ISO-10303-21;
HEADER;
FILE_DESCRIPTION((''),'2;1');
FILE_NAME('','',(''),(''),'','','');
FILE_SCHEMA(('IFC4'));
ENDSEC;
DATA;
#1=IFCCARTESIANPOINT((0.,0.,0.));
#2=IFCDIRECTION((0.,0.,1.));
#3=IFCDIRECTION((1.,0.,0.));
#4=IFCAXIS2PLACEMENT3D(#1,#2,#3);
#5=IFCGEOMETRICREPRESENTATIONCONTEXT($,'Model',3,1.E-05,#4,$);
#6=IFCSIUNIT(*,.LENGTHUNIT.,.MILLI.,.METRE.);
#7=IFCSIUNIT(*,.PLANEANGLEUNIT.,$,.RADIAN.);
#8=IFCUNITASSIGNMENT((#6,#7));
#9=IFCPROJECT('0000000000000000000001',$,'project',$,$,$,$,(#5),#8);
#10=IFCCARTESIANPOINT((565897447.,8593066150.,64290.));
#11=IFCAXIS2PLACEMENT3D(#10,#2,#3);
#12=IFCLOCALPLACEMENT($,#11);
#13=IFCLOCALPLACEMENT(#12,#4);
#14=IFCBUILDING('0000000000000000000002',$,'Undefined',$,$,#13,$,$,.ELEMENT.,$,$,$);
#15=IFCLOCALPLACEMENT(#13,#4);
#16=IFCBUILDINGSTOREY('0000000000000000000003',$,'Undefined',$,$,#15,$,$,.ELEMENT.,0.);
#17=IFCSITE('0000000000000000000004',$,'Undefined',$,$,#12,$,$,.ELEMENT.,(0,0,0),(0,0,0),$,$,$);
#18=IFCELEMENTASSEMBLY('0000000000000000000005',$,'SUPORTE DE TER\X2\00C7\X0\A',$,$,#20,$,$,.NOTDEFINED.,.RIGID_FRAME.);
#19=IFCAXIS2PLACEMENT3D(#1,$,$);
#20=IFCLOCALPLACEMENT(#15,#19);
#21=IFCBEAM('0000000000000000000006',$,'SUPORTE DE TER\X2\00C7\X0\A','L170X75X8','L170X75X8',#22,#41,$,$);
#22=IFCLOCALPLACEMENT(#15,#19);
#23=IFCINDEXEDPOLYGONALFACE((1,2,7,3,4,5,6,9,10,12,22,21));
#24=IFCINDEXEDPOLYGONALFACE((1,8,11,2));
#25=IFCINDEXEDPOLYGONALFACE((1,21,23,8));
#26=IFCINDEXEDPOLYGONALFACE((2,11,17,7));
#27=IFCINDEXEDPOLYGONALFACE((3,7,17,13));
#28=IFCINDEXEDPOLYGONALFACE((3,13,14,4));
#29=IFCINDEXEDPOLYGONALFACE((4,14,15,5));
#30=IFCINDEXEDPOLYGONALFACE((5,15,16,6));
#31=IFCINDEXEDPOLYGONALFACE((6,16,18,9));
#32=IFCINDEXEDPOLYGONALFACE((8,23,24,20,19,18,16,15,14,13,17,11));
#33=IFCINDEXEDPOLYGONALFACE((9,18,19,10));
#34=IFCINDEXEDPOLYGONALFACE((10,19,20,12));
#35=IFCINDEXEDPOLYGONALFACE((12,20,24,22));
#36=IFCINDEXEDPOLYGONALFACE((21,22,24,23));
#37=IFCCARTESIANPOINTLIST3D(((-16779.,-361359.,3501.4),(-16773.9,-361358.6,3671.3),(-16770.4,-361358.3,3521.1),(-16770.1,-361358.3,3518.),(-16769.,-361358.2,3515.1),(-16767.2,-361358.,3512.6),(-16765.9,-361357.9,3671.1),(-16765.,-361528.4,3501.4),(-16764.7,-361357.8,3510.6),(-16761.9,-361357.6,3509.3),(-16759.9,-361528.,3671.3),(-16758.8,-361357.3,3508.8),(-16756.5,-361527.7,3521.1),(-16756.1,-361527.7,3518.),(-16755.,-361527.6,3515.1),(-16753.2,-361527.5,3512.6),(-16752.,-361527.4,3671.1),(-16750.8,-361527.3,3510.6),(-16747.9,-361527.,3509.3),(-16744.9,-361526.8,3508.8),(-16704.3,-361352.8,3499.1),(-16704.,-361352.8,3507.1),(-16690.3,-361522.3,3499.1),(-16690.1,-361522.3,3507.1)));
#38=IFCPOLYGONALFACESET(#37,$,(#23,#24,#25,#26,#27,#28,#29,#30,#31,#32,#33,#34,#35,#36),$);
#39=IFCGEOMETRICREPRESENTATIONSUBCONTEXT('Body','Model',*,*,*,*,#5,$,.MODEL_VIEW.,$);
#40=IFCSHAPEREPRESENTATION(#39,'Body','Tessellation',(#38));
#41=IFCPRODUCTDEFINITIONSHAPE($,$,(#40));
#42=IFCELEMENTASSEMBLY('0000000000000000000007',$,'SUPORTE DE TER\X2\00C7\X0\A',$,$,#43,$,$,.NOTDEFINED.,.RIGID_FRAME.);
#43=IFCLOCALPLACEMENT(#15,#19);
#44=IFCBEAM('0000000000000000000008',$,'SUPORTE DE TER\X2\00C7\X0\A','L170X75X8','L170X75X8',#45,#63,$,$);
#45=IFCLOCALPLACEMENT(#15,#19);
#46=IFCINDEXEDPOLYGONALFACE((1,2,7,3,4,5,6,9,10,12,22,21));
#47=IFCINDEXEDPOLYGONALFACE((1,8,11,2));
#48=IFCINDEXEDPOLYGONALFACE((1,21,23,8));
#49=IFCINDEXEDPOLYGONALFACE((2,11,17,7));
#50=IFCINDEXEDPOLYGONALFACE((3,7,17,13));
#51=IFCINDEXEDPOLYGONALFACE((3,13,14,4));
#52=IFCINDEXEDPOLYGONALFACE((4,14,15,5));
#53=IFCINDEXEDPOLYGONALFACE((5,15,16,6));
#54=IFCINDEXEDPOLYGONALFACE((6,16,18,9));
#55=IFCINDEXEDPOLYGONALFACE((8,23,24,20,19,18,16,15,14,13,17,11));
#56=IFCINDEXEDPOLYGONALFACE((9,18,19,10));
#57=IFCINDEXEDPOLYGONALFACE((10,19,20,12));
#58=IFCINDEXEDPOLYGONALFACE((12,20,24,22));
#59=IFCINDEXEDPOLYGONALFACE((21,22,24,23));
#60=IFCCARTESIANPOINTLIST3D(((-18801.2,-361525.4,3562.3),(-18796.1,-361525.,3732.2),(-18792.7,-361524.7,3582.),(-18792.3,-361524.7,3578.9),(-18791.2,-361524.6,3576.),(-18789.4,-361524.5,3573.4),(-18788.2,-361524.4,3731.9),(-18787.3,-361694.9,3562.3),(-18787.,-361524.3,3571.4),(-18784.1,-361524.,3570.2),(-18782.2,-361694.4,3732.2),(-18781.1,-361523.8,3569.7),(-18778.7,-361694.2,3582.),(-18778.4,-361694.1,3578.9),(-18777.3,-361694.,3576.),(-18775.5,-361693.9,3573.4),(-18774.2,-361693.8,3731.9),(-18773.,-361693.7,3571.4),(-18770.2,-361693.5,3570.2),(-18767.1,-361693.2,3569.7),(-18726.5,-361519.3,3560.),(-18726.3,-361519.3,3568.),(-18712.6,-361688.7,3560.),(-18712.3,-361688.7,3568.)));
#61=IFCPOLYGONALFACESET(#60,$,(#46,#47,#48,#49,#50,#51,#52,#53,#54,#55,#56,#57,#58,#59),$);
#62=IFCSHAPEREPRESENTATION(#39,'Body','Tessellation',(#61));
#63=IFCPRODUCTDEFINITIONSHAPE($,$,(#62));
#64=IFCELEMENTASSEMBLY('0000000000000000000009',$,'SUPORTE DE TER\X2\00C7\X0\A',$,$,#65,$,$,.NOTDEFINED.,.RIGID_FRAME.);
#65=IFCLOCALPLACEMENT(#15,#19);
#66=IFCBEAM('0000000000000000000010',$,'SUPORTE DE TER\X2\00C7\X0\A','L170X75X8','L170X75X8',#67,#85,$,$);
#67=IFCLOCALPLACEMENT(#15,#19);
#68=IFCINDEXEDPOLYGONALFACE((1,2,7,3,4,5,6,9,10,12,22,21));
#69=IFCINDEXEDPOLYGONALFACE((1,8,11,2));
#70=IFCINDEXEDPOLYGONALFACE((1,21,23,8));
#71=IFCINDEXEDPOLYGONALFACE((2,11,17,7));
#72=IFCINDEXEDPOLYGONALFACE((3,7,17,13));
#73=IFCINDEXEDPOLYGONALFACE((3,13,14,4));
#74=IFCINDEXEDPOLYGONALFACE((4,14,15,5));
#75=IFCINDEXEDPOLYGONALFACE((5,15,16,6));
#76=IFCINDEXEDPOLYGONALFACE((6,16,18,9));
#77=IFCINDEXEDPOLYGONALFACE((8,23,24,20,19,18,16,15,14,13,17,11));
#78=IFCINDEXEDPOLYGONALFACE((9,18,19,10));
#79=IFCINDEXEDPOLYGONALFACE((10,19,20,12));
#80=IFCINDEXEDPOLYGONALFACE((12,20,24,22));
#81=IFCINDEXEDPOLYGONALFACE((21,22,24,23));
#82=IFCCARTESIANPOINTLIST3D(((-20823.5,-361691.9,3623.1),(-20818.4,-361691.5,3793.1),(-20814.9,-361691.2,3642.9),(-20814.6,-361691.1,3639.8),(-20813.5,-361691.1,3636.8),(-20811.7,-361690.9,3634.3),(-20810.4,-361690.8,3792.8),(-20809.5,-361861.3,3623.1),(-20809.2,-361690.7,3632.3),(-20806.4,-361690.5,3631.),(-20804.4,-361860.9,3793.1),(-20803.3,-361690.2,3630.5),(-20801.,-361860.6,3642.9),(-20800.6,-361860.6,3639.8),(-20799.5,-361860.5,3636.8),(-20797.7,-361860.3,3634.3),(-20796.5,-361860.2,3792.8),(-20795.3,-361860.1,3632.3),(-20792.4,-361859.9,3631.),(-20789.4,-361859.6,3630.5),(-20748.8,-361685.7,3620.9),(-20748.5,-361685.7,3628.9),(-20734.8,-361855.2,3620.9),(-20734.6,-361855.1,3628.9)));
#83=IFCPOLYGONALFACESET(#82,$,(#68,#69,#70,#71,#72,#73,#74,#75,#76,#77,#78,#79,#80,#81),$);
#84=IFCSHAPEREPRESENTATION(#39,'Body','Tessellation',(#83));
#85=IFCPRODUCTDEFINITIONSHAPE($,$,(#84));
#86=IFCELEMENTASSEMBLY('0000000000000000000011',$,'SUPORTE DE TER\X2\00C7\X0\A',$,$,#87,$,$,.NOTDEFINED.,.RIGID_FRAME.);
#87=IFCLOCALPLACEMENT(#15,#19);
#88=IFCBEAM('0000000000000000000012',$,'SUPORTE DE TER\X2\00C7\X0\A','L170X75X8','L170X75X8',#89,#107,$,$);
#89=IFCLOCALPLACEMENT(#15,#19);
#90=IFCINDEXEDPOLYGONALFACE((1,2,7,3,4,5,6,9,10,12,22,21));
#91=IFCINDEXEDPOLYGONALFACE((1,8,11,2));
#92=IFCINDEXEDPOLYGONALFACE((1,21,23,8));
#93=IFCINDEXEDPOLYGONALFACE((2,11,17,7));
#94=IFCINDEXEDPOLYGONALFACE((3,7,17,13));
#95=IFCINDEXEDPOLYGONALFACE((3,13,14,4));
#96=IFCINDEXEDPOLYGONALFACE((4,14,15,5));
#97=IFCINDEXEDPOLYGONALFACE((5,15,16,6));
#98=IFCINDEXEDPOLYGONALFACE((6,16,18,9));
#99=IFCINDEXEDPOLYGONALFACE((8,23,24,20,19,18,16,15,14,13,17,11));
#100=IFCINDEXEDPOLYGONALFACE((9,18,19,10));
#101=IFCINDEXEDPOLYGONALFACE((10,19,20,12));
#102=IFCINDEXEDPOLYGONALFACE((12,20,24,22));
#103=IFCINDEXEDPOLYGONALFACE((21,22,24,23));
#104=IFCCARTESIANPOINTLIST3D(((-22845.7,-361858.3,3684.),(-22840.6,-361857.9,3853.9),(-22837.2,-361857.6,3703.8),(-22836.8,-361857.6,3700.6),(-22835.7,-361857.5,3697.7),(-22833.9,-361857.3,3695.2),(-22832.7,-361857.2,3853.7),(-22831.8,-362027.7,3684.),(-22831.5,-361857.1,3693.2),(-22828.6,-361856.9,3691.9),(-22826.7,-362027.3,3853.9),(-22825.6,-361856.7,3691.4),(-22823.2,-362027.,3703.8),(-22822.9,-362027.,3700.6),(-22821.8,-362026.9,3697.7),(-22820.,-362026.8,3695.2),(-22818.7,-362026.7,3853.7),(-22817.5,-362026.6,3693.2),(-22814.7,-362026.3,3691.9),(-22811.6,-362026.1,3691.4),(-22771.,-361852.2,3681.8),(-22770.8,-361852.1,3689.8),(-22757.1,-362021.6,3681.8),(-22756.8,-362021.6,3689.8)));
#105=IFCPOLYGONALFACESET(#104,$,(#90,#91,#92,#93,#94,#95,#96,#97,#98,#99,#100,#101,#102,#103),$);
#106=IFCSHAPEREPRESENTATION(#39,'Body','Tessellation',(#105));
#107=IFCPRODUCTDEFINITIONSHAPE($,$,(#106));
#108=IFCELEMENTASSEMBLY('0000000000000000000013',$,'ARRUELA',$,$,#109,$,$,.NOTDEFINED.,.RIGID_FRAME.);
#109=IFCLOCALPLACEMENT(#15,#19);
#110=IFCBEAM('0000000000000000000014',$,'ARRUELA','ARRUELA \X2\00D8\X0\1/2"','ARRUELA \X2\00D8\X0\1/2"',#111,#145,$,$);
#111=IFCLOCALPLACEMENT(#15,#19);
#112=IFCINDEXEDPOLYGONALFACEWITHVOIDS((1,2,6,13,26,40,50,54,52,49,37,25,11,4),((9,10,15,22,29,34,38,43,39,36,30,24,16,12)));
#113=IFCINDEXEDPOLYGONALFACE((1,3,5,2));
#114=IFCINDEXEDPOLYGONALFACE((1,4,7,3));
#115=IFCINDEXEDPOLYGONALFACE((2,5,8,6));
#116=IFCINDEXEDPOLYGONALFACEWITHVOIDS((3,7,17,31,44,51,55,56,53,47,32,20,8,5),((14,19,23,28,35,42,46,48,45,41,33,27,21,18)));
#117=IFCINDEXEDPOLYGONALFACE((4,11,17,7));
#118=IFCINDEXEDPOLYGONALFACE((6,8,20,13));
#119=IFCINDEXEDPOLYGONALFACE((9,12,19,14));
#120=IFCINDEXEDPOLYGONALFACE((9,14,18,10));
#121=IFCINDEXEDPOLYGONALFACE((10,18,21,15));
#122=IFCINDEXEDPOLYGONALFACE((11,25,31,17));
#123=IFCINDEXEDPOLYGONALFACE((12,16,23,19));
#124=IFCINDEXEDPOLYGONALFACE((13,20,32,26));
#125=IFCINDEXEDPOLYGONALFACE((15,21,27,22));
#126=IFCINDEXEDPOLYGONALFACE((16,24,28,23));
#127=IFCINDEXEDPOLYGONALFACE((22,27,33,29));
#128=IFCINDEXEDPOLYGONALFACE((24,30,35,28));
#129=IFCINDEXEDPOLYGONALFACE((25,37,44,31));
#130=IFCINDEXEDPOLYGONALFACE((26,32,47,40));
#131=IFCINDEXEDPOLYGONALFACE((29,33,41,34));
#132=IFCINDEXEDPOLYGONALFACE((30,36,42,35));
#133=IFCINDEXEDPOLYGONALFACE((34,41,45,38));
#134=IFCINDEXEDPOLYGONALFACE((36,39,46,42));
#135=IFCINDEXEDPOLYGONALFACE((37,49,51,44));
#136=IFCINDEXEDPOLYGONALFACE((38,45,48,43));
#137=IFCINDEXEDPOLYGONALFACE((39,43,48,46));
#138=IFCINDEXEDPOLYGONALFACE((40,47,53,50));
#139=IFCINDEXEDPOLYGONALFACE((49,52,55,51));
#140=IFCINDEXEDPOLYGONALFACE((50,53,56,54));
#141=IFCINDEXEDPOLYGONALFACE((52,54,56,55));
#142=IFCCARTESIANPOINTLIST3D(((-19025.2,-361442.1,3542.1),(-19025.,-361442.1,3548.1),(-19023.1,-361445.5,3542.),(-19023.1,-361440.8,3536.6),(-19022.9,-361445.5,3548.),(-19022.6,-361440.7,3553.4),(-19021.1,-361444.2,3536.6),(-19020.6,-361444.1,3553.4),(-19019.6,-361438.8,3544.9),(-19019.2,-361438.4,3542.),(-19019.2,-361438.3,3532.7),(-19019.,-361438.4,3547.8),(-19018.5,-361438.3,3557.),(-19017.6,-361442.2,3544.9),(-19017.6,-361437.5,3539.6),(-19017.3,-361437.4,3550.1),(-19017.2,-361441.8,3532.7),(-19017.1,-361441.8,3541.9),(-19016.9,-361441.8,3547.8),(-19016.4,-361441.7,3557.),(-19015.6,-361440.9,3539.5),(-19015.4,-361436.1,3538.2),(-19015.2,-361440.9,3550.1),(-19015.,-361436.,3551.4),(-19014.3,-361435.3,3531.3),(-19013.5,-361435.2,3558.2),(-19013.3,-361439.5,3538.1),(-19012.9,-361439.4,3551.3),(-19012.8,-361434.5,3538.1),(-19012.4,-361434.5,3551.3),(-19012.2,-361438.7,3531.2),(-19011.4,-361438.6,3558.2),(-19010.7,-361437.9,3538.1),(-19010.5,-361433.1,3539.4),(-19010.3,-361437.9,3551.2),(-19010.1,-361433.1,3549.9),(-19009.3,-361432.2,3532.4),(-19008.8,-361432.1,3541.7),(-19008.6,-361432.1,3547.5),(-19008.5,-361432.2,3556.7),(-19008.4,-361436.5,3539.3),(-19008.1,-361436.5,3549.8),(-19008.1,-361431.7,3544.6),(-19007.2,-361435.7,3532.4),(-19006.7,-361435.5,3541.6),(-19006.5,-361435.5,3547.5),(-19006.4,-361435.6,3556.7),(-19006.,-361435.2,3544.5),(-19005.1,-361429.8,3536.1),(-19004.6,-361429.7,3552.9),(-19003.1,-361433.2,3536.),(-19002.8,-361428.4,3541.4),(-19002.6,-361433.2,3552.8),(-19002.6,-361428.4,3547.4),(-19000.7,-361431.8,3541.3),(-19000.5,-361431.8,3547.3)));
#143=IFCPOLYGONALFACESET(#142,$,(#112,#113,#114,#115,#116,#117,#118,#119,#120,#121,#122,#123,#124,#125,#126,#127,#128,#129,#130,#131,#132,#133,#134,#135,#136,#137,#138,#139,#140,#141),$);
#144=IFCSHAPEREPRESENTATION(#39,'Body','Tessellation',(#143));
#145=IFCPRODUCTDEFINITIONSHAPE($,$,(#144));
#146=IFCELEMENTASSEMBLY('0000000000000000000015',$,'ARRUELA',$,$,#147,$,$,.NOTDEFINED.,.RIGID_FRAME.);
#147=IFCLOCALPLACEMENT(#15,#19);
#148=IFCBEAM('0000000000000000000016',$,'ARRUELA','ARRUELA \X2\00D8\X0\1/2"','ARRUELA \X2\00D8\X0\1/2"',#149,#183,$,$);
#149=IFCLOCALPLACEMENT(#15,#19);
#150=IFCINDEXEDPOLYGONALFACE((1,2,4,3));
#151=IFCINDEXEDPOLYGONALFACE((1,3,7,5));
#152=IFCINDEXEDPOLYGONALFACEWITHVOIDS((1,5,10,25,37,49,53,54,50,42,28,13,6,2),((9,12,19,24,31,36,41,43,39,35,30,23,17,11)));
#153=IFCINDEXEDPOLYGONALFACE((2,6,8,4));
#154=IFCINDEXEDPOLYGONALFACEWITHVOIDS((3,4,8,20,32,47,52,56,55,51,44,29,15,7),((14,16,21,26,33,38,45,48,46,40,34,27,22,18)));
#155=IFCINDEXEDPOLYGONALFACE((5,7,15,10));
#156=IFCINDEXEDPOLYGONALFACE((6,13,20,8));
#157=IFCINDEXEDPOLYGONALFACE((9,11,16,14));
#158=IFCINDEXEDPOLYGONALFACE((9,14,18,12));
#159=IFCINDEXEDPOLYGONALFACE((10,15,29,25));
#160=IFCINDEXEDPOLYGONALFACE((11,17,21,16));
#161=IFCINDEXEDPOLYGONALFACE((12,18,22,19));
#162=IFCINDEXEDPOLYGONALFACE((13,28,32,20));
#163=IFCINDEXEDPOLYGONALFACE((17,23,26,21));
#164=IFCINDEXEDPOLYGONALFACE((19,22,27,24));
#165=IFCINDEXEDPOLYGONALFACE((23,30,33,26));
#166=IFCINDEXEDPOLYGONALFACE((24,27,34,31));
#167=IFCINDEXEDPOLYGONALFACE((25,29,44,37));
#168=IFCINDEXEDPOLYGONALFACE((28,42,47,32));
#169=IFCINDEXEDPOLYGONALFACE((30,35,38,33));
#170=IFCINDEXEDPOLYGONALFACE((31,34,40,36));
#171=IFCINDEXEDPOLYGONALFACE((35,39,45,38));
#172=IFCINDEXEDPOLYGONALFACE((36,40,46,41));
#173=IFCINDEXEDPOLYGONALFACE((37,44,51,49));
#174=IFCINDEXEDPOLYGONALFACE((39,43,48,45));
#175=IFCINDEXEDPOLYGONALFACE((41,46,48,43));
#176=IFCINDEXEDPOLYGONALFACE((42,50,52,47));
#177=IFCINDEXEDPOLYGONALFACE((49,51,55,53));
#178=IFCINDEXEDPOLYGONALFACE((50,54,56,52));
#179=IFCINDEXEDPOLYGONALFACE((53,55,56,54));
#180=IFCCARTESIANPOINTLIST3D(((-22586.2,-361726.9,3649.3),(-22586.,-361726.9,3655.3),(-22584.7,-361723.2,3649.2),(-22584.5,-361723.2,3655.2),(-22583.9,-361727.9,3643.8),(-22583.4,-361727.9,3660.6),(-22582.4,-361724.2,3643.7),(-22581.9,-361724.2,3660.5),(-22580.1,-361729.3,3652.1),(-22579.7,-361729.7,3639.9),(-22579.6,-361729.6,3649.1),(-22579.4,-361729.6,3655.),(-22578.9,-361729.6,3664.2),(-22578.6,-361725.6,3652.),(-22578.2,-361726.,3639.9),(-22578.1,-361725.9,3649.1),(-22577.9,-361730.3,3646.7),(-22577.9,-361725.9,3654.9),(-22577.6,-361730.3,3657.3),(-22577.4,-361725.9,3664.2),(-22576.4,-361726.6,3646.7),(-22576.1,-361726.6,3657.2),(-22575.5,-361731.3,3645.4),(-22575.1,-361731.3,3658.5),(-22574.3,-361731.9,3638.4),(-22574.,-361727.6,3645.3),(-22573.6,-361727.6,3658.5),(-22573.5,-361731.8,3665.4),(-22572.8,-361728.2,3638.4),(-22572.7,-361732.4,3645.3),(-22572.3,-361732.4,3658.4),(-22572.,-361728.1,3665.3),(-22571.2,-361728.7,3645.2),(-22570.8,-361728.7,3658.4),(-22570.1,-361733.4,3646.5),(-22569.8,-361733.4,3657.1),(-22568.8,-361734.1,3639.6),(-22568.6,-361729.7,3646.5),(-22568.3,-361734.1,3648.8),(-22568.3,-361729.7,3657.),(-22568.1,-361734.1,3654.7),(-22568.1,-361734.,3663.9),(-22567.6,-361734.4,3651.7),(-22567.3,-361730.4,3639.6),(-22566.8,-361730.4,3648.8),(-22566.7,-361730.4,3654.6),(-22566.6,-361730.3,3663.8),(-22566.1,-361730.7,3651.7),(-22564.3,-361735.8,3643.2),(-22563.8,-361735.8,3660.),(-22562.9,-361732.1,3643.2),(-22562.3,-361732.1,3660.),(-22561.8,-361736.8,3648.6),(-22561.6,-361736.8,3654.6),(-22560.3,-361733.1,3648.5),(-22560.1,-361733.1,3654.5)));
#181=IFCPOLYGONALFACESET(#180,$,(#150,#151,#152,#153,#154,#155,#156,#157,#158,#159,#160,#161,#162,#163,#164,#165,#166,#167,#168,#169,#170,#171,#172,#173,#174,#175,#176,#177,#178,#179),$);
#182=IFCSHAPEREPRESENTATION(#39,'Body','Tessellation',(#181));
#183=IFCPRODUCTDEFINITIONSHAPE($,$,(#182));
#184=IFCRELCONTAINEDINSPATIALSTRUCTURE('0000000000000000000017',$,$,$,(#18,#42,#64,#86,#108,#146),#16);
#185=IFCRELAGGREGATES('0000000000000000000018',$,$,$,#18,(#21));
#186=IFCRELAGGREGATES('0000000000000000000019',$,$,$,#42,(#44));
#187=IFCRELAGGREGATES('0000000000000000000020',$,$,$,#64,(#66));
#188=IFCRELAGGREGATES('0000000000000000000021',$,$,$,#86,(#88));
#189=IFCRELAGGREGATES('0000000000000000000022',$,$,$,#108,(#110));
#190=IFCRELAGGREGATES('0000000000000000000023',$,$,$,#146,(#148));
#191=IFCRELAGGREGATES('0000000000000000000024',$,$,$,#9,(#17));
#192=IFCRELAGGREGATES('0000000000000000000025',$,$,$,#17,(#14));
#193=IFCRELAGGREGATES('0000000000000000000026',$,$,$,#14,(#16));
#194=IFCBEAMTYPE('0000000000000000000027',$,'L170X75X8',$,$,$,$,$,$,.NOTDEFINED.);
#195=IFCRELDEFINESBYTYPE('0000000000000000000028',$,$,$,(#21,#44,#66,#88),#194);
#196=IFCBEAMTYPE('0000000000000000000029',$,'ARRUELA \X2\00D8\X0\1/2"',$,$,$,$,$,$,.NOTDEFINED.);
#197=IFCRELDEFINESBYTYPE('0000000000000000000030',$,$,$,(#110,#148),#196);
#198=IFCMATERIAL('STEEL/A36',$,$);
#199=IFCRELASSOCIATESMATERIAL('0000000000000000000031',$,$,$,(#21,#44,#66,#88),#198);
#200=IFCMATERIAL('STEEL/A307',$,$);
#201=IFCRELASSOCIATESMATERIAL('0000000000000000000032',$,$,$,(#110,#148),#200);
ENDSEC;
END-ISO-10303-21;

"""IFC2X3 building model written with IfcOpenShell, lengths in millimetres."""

from ifc_helpers import new_model, si_unit, frame, origin_with_axes, origin_2d_with_axis, place, context, subcontext, project, spatial, polyline, l_section, outline, extrude, material, type_object, element, aggregate, save


model = new_model("IFC2X3")

# Units and contexts
model_context = context("Model", 3, precision=1e-05, world=origin_with_axes())
body_context = subcontext(model_context, "Body", "Model", "MODEL_VIEW")
ifc_project = project(units=[si_unit("LENGTHUNIT", "METRE", prefix="MILLI"), si_unit("PLANEANGLEUNIT", "RADIAN")], contexts=[model_context])

# Site, building, storey
site_placement = place(None, frame((565897447.0, 8593066150.0, 64290.0), z_axis=(0.0, 0.0, 1.0), x_axis=(1.0, 0.0, 0.0)))
site = spatial("IfcSite", under=ifc_project, at=site_placement, Name="Undefined", CompositionType="ELEMENT", RefLatitude=(0, 0, 0), RefLongitude=(0, 0, 0))
building_placement = place(site_placement, origin_with_axes())
building = spatial("IfcBuilding", under=site, at=building_placement, Name="Undefined", CompositionType="ELEMENT")
storey_placement = place(building_placement, origin_with_axes())
storey = spatial("IfcBuildingStorey", under=building, at=storey_placement, Name="Undefined", CompositionType="ELEMENT", Elevation=0.0)

# Element assemblies, beams
ifc_material_1 = material(Name="STEEL/A36")
beam_type_1 = type_object("IfcBeamType", Name="L170X75X8", PredefinedType="NOTDEFINED")
assembly_1_placement = place(storey_placement, origin_with_axes())
assembly_1 = element("IfcElementAssembly", 1, at=assembly_1_placement, inside=storey, Name="SUPORTE DE TERÇA", AssemblyPlace="NOTDEFINED", PredefinedType="RIGID_FRAME")
beam_1_placement = place(assembly_1_placement, frame((-16725.1, -361525.1, 3585.2), z_axis=(0.029885, 0.00246, 0.99955), x_axis=(-0.082025, 0.99663, 0.0)))
beam_1 = element("IfcBeam", 2, at=beam_1_placement, type_object=beam_type_1, material=ifc_material_1, Name="SUPORTE DE TERÇA", Description="L170X75X8", ObjectType="L170X75X8", context=body_context, shape_type="SweptSolid", body=[
    extrude(l_section(Depth=170.0, Width=75.0, Thickness=8.0, FilletRadius=12.0, at=origin_2d_with_axis()), frame((170.0, 0.0, 0.0), z_axis=(-1.0, 0.0, 0.0), x_axis=(0.0, -1.0, 0.0)), (0.0, 0.0, 1.0), 170.0),
])
aggregate(assembly_1, [beam_1])
assembly_2_placement = place(storey_placement, origin_with_axes())
assembly_2 = element("IfcElementAssembly", 3, at=assembly_2_placement, inside=storey, Name="SUPORTE DE TERÇA", AssemblyPlace="NOTDEFINED", PredefinedType="RIGID_FRAME")
beam_2_placement = place(assembly_2_placement, frame((-18747.4, -361691.6, 3646.1), z_axis=(0.029885, 0.00246, 0.99955), x_axis=(-0.082025, 0.99663, 0.0)))
beam_2 = element("IfcBeam", 4, at=beam_2_placement, type_object=beam_type_1, material=ifc_material_1, Name="SUPORTE DE TERÇA", Description="L170X75X8", ObjectType="L170X75X8", context=body_context, shape_type="SweptSolid", body=[
    extrude(l_section(Depth=170.0, Width=75.0, Thickness=8.0, FilletRadius=12.0, at=origin_2d_with_axis()), frame((170.0, 0.0, 0.0), z_axis=(-1.0, 0.0, 0.0), x_axis=(0.0, -1.0, 0.0)), (0.0, 0.0, 1.0), 170.0),
])
aggregate(assembly_2, [beam_2])
assembly_3_placement = place(storey_placement, origin_with_axes())
assembly_3 = element("IfcElementAssembly", 5, at=assembly_3_placement, inside=storey, Name="SUPORTE DE TERÇA", AssemblyPlace="NOTDEFINED", PredefinedType="RIGID_FRAME")
beam_3_placement = place(assembly_3_placement, frame((-20769.6, -361858.0, 3707.0), z_axis=(0.029885, 0.00246, 0.99955), x_axis=(-0.082025, 0.99663, 0.0)))
beam_3 = element("IfcBeam", 6, at=beam_3_placement, type_object=beam_type_1, material=ifc_material_1, Name="SUPORTE DE TERÇA", Description="L170X75X8", ObjectType="L170X75X8", context=body_context, shape_type="SweptSolid", body=[
    extrude(l_section(Depth=170.0, Width=75.0, Thickness=8.0, FilletRadius=12.0, at=origin_2d_with_axis()), frame((170.0, 0.0, 0.0), z_axis=(-1.0, 0.0, 0.0), x_axis=(0.0, -1.0, 0.0)), (0.0, 0.0, 1.0), 170.0),
])
aggregate(assembly_3, [beam_3])
assembly_4_placement = place(storey_placement, origin_with_axes())
assembly_4 = element("IfcElementAssembly", 7, at=assembly_4_placement, inside=storey, Name="SUPORTE DE TERÇA", AssemblyPlace="NOTDEFINED", PredefinedType="RIGID_FRAME")
beam_4_placement = place(assembly_4_placement, frame((-22791.9, -362024.5, 3767.8), z_axis=(0.029885, 0.00246, 0.99955), x_axis=(-0.082025, 0.99663, 0.0)))
beam_4 = element("IfcBeam", 8, at=beam_4_placement, type_object=beam_type_1, material=ifc_material_1, Name="SUPORTE DE TERÇA", Description="L170X75X8", ObjectType="L170X75X8", context=body_context, shape_type="SweptSolid", body=[
    extrude(l_section(Depth=170.0, Width=75.0, Thickness=8.0, FilletRadius=12.0, at=origin_2d_with_axis()), frame((170.0, 0.0, 0.0), z_axis=(-1.0, 0.0, 0.0), x_axis=(0.0, -1.0, 0.0)), (0.0, 0.0, 1.0), 170.0),
])
aggregate(assembly_4, [beam_4])
assembly_5_placement = place(storey_placement, origin_with_axes())
assembly_5 = element("IfcElementAssembly", 9, at=assembly_5_placement, inside=storey, Name="ARRUELA", AssemblyPlace="NOTDEFINED", PredefinedType="RIGID_FRAME")
ifc_material_2 = material(Name="STEEL/A307")
beam_type_2 = type_object("IfcBeamType", Name="ARRUELA Ø1/2\"", PredefinedType="NOTDEFINED")
beam_5_placement = place(assembly_5_placement, frame((-19011.8, -361438.7, 3544.7), z_axis=(-0.853486, -0.520426, 0.026799), x_axis=(-0.520257, 0.853904, 0.013454)))
beam_5 = element("IfcBeam", 10, at=beam_5_placement, type_object=beam_type_2, material=ifc_material_2, Name="ARRUELA", Description="ARRUELA Ø1/2\"", ObjectType="ARRUELA Ø1/2\"", context=body_context, shape_type="SweptSolid", body=[
    extrude(outline(polyline([(-8.4, 10.5), (-3.0, 13.2), (3.0, 13.2), (8.4, 10.5), (12.2, 5.9), (13.5, 0.0), (12.2, -5.9), (8.4, -10.5), (3.0, -13.2), (-3.0, -13.2), (-8.4, -10.5), (-12.2, -5.9), (-13.5, 0.0), (-12.2, 5.9), (-8.4, 10.5)]), holes=[polyline([(5.3, 4.2), (2.9, 6.1), (0.0, 6.7), (-2.9, 6.1), (-5.3, 4.2), (-6.6, 1.5), (-6.6, -1.5), (-5.3, -4.2), (-2.9, -6.1), (0.0, -6.8), (2.9, -6.1), (5.3, -4.2), (6.6, -1.5), (6.6, 1.5), (5.3, 4.2)])]), frame((4.0, 0.0, 0.0), z_axis=(-1.0, 0.0, 0.0), x_axis=(0.0, -1.0, 0.0)), (0.0, 0.0, 1.0), 4.0),
])
aggregate(assembly_5, [beam_5])
assembly_6_placement = place(storey_placement, origin_with_axes())
assembly_6 = element("IfcElementAssembly", 11, at=assembly_6_placement, inside=storey, Name="ARRUELA", AssemblyPlace="NOTDEFINED", PredefinedType="RIGID_FRAME")
beam_6_placement = place(assembly_6_placement, frame((-22573.9, -361731.9, 3651.9), z_axis=(-0.92709, 0.373879, 0.026799), x_axis=(0.373645, 0.927474, -0.013454)))
beam_6 = element("IfcBeam", 12, at=beam_6_placement, type_object=beam_type_2, material=ifc_material_2, Name="ARRUELA", Description="ARRUELA Ø1/2\"", ObjectType="ARRUELA Ø1/2\"", context=body_context, shape_type="SweptSolid", body=[
    extrude(outline(polyline([(-8.4, 10.5), (-3.0, 13.2), (3.0, 13.2), (8.4, 10.5), (12.2, 5.9), (13.5, 0.0), (12.2, -5.9), (8.4, -10.5), (3.0, -13.2), (-3.0, -13.2), (-8.4, -10.5), (-12.2, -5.9), (-13.5, 0.0), (-12.2, 5.9), (-8.4, 10.5)]), holes=[polyline([(5.3, 4.2), (2.9, 6.1), (0.0, 6.7), (-2.9, 6.1), (-5.3, 4.2), (-6.6, 1.5), (-6.6, -1.5), (-5.3, -4.2), (-2.9, -6.1), (0.0, -6.8), (2.9, -6.1), (5.3, -4.2), (6.6, -1.5), (6.6, 1.5), (5.3, 4.2)])]), frame((4.0, 0.0, 0.0), z_axis=(-1.0, 0.0, 0.0), x_axis=(0.0, -1.0, 0.0)), (0.0, 0.0, 1.0), 4.0),
])
aggregate(assembly_6, [beam_6])

save(model, "model.ifc")
